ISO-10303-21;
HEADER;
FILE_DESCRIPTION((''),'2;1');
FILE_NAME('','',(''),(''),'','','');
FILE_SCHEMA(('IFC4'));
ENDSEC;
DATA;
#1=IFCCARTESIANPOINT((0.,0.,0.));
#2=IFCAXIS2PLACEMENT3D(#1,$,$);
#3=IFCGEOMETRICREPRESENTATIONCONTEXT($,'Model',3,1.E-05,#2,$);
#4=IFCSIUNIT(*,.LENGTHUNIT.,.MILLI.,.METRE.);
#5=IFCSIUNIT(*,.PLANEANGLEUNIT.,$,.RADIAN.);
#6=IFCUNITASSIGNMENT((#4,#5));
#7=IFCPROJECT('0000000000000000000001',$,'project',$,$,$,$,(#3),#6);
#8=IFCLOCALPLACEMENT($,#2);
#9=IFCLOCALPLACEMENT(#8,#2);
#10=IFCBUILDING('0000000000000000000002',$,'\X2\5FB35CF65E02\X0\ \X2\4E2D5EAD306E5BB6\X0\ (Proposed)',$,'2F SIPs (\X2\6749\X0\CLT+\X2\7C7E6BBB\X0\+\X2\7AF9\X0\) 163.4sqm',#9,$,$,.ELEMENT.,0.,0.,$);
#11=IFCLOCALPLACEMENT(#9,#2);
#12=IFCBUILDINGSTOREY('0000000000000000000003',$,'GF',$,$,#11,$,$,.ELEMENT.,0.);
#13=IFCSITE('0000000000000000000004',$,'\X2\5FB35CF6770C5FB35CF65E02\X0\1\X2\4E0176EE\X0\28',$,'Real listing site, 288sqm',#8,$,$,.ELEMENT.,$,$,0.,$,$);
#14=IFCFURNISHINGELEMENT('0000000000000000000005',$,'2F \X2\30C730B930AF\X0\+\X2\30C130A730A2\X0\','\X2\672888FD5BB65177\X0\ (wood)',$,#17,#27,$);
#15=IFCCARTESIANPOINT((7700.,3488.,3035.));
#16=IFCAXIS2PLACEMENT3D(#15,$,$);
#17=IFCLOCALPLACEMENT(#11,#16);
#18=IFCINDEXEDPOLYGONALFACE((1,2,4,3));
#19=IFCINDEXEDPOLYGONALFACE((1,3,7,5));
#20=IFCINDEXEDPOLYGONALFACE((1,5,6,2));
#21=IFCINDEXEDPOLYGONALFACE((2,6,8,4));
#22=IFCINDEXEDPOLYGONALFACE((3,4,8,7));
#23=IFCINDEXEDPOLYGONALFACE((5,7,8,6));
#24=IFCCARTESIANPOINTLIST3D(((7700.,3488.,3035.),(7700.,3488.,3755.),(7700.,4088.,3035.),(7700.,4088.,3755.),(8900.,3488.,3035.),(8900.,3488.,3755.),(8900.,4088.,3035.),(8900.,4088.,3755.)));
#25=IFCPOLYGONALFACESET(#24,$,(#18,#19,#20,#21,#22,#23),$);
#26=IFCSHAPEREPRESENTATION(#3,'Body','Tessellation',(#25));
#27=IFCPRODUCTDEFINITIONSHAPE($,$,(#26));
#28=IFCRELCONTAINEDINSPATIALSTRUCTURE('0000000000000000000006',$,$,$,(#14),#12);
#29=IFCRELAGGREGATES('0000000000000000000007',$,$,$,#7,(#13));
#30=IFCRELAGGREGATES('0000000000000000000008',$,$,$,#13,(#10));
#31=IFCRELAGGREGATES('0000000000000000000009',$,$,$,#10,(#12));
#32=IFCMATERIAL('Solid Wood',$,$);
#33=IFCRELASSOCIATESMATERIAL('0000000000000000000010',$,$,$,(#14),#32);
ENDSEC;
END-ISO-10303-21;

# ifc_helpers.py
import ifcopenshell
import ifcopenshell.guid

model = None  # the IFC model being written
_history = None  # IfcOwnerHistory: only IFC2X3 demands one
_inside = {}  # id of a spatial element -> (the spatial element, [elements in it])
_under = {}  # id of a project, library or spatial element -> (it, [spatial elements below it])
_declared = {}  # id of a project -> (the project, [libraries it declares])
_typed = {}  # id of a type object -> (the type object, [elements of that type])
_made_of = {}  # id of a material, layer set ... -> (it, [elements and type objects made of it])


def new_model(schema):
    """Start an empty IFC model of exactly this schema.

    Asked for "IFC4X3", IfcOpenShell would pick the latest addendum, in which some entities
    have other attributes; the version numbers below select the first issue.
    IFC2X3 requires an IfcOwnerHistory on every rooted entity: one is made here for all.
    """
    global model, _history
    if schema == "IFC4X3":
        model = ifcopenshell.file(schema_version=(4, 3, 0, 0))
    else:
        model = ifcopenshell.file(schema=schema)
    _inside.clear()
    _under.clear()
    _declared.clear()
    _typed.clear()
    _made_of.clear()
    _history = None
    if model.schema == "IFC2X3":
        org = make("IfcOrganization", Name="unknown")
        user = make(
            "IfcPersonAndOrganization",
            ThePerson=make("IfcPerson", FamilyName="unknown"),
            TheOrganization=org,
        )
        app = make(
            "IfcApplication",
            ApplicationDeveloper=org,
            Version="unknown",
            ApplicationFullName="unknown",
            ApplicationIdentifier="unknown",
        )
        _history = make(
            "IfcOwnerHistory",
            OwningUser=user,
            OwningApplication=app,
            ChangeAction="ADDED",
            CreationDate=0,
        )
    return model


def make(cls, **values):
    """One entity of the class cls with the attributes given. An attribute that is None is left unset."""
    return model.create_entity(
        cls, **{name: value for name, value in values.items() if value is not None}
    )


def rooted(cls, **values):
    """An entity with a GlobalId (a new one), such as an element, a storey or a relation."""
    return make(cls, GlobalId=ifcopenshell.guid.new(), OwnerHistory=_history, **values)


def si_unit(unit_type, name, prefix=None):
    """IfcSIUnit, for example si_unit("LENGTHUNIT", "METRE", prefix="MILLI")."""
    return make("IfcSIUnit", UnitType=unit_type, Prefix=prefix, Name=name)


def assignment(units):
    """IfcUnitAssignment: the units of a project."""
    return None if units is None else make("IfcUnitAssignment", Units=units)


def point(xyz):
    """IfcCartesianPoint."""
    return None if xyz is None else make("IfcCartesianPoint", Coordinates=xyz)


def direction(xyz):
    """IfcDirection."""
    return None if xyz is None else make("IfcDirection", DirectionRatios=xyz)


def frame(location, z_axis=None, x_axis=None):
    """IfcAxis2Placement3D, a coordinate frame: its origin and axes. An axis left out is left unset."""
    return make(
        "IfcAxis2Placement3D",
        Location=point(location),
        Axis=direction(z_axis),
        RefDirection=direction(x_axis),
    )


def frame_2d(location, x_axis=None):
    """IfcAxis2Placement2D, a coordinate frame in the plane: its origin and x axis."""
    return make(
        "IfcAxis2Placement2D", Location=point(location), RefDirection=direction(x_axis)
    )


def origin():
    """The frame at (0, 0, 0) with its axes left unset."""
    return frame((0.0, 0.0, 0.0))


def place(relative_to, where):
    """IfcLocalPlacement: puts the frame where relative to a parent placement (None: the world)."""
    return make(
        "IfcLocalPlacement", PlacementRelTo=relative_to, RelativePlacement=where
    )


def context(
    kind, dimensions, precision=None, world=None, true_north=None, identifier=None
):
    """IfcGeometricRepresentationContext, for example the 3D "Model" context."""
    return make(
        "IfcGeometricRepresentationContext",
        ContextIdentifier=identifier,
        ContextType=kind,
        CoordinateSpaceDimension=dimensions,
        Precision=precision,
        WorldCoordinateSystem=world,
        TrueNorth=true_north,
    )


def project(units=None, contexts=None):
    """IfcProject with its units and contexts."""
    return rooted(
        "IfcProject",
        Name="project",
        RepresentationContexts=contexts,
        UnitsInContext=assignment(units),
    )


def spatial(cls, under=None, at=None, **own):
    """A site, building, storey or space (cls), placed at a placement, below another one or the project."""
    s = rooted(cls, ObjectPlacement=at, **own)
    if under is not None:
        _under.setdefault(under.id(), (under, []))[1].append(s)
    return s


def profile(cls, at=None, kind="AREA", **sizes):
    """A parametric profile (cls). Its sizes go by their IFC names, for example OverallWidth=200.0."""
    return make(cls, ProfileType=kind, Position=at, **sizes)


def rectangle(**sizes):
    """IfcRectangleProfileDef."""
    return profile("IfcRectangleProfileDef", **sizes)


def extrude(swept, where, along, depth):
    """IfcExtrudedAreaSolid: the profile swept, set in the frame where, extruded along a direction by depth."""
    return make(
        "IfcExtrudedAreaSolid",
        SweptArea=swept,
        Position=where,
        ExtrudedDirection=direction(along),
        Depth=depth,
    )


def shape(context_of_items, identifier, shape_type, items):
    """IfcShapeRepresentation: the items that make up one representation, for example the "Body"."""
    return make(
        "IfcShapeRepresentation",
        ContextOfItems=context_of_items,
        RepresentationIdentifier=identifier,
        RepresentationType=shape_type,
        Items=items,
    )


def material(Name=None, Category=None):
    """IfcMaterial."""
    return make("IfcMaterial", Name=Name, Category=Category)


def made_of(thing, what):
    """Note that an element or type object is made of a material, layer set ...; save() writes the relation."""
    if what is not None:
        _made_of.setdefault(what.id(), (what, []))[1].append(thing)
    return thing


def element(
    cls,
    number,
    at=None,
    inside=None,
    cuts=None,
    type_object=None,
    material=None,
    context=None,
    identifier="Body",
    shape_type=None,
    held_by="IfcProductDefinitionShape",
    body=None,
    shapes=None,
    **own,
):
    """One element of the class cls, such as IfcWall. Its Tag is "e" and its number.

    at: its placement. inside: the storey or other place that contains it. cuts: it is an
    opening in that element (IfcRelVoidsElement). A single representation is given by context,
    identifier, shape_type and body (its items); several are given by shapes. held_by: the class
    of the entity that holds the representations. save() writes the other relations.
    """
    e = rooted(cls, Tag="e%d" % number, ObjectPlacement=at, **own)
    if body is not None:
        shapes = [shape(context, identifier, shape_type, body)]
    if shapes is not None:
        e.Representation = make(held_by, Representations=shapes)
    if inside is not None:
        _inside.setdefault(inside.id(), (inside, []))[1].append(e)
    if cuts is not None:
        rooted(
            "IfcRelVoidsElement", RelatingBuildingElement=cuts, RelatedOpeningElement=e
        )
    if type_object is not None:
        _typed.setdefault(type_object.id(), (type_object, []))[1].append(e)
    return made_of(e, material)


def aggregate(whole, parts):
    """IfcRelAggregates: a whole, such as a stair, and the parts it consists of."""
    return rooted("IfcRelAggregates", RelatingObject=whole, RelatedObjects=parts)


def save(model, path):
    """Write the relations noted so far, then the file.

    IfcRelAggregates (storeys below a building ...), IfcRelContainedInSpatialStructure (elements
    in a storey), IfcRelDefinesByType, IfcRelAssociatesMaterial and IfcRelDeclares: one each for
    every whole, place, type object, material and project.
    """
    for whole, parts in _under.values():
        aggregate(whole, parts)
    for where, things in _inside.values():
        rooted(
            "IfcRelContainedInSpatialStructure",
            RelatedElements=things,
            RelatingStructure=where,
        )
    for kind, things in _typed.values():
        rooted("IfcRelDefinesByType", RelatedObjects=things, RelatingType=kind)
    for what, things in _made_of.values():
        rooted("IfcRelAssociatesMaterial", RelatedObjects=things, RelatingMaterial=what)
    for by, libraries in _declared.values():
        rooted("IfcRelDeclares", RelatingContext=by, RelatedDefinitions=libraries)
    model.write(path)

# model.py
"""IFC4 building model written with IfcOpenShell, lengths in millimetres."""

from ifc_helpers import new_model, si_unit, frame, frame_2d, origin, place, context, project, spatial, rectangle, extrude, material, element, save


model = new_model("IFC4")

# Units and contexts
model_context = context("Model", 3, precision=1e-05, world=origin())
ifc_project = project(units=[si_unit("LENGTHUNIT", "METRE", prefix="MILLI"), si_unit("PLANEANGLEUNIT", "RADIAN")], contexts=[model_context])

# Site, building, storey
site_placement = place(None, origin())
site = spatial("IfcSite", under=ifc_project, at=site_placement, Name="徳島県徳島市1丁目28", ObjectType="Real listing site, 288sqm", CompositionType="ELEMENT", RefElevation=0.0)
building_placement = place(site_placement, origin())
building = spatial("IfcBuilding", under=site, at=building_placement, Name="徳島市 中庭の家 (Proposed)", ObjectType="2F SIPs (杉CLT+籾殻+竹) 163.4sqm", CompositionType="ELEMENT", ElevationOfRefHeight=0.0, ElevationOfTerrain=0.0)
storey_placement = place(building_placement, origin())
storey = spatial("IfcBuildingStorey", under=building, at=storey_placement, Name="GF", CompositionType="ELEMENT", Elevation=0.0)

# Shared definitions
ifc_material_1 = material(Name="Solid Wood")

# Furnishing element
furnishing_1_placement = place(storey_placement, frame((7700.0, 3488.0, 3035.0)))
element("IfcFurnishingElement", 1, at=furnishing_1_placement, inside=storey, material=ifc_material_1, Name="2F デスク+チェア", Description="木製家具 (wood)", context=model_context, shape_type="SweptSolid", body=[
    extrude(rectangle(XDim=1200.0, YDim=600.0, at=frame_2d((600.0, 300.0))), frame((7700.0, 3488.0, 3035.0)), (0.0, 0.0, 1.0), 720.0),
])

save(model, "model.ifc")
